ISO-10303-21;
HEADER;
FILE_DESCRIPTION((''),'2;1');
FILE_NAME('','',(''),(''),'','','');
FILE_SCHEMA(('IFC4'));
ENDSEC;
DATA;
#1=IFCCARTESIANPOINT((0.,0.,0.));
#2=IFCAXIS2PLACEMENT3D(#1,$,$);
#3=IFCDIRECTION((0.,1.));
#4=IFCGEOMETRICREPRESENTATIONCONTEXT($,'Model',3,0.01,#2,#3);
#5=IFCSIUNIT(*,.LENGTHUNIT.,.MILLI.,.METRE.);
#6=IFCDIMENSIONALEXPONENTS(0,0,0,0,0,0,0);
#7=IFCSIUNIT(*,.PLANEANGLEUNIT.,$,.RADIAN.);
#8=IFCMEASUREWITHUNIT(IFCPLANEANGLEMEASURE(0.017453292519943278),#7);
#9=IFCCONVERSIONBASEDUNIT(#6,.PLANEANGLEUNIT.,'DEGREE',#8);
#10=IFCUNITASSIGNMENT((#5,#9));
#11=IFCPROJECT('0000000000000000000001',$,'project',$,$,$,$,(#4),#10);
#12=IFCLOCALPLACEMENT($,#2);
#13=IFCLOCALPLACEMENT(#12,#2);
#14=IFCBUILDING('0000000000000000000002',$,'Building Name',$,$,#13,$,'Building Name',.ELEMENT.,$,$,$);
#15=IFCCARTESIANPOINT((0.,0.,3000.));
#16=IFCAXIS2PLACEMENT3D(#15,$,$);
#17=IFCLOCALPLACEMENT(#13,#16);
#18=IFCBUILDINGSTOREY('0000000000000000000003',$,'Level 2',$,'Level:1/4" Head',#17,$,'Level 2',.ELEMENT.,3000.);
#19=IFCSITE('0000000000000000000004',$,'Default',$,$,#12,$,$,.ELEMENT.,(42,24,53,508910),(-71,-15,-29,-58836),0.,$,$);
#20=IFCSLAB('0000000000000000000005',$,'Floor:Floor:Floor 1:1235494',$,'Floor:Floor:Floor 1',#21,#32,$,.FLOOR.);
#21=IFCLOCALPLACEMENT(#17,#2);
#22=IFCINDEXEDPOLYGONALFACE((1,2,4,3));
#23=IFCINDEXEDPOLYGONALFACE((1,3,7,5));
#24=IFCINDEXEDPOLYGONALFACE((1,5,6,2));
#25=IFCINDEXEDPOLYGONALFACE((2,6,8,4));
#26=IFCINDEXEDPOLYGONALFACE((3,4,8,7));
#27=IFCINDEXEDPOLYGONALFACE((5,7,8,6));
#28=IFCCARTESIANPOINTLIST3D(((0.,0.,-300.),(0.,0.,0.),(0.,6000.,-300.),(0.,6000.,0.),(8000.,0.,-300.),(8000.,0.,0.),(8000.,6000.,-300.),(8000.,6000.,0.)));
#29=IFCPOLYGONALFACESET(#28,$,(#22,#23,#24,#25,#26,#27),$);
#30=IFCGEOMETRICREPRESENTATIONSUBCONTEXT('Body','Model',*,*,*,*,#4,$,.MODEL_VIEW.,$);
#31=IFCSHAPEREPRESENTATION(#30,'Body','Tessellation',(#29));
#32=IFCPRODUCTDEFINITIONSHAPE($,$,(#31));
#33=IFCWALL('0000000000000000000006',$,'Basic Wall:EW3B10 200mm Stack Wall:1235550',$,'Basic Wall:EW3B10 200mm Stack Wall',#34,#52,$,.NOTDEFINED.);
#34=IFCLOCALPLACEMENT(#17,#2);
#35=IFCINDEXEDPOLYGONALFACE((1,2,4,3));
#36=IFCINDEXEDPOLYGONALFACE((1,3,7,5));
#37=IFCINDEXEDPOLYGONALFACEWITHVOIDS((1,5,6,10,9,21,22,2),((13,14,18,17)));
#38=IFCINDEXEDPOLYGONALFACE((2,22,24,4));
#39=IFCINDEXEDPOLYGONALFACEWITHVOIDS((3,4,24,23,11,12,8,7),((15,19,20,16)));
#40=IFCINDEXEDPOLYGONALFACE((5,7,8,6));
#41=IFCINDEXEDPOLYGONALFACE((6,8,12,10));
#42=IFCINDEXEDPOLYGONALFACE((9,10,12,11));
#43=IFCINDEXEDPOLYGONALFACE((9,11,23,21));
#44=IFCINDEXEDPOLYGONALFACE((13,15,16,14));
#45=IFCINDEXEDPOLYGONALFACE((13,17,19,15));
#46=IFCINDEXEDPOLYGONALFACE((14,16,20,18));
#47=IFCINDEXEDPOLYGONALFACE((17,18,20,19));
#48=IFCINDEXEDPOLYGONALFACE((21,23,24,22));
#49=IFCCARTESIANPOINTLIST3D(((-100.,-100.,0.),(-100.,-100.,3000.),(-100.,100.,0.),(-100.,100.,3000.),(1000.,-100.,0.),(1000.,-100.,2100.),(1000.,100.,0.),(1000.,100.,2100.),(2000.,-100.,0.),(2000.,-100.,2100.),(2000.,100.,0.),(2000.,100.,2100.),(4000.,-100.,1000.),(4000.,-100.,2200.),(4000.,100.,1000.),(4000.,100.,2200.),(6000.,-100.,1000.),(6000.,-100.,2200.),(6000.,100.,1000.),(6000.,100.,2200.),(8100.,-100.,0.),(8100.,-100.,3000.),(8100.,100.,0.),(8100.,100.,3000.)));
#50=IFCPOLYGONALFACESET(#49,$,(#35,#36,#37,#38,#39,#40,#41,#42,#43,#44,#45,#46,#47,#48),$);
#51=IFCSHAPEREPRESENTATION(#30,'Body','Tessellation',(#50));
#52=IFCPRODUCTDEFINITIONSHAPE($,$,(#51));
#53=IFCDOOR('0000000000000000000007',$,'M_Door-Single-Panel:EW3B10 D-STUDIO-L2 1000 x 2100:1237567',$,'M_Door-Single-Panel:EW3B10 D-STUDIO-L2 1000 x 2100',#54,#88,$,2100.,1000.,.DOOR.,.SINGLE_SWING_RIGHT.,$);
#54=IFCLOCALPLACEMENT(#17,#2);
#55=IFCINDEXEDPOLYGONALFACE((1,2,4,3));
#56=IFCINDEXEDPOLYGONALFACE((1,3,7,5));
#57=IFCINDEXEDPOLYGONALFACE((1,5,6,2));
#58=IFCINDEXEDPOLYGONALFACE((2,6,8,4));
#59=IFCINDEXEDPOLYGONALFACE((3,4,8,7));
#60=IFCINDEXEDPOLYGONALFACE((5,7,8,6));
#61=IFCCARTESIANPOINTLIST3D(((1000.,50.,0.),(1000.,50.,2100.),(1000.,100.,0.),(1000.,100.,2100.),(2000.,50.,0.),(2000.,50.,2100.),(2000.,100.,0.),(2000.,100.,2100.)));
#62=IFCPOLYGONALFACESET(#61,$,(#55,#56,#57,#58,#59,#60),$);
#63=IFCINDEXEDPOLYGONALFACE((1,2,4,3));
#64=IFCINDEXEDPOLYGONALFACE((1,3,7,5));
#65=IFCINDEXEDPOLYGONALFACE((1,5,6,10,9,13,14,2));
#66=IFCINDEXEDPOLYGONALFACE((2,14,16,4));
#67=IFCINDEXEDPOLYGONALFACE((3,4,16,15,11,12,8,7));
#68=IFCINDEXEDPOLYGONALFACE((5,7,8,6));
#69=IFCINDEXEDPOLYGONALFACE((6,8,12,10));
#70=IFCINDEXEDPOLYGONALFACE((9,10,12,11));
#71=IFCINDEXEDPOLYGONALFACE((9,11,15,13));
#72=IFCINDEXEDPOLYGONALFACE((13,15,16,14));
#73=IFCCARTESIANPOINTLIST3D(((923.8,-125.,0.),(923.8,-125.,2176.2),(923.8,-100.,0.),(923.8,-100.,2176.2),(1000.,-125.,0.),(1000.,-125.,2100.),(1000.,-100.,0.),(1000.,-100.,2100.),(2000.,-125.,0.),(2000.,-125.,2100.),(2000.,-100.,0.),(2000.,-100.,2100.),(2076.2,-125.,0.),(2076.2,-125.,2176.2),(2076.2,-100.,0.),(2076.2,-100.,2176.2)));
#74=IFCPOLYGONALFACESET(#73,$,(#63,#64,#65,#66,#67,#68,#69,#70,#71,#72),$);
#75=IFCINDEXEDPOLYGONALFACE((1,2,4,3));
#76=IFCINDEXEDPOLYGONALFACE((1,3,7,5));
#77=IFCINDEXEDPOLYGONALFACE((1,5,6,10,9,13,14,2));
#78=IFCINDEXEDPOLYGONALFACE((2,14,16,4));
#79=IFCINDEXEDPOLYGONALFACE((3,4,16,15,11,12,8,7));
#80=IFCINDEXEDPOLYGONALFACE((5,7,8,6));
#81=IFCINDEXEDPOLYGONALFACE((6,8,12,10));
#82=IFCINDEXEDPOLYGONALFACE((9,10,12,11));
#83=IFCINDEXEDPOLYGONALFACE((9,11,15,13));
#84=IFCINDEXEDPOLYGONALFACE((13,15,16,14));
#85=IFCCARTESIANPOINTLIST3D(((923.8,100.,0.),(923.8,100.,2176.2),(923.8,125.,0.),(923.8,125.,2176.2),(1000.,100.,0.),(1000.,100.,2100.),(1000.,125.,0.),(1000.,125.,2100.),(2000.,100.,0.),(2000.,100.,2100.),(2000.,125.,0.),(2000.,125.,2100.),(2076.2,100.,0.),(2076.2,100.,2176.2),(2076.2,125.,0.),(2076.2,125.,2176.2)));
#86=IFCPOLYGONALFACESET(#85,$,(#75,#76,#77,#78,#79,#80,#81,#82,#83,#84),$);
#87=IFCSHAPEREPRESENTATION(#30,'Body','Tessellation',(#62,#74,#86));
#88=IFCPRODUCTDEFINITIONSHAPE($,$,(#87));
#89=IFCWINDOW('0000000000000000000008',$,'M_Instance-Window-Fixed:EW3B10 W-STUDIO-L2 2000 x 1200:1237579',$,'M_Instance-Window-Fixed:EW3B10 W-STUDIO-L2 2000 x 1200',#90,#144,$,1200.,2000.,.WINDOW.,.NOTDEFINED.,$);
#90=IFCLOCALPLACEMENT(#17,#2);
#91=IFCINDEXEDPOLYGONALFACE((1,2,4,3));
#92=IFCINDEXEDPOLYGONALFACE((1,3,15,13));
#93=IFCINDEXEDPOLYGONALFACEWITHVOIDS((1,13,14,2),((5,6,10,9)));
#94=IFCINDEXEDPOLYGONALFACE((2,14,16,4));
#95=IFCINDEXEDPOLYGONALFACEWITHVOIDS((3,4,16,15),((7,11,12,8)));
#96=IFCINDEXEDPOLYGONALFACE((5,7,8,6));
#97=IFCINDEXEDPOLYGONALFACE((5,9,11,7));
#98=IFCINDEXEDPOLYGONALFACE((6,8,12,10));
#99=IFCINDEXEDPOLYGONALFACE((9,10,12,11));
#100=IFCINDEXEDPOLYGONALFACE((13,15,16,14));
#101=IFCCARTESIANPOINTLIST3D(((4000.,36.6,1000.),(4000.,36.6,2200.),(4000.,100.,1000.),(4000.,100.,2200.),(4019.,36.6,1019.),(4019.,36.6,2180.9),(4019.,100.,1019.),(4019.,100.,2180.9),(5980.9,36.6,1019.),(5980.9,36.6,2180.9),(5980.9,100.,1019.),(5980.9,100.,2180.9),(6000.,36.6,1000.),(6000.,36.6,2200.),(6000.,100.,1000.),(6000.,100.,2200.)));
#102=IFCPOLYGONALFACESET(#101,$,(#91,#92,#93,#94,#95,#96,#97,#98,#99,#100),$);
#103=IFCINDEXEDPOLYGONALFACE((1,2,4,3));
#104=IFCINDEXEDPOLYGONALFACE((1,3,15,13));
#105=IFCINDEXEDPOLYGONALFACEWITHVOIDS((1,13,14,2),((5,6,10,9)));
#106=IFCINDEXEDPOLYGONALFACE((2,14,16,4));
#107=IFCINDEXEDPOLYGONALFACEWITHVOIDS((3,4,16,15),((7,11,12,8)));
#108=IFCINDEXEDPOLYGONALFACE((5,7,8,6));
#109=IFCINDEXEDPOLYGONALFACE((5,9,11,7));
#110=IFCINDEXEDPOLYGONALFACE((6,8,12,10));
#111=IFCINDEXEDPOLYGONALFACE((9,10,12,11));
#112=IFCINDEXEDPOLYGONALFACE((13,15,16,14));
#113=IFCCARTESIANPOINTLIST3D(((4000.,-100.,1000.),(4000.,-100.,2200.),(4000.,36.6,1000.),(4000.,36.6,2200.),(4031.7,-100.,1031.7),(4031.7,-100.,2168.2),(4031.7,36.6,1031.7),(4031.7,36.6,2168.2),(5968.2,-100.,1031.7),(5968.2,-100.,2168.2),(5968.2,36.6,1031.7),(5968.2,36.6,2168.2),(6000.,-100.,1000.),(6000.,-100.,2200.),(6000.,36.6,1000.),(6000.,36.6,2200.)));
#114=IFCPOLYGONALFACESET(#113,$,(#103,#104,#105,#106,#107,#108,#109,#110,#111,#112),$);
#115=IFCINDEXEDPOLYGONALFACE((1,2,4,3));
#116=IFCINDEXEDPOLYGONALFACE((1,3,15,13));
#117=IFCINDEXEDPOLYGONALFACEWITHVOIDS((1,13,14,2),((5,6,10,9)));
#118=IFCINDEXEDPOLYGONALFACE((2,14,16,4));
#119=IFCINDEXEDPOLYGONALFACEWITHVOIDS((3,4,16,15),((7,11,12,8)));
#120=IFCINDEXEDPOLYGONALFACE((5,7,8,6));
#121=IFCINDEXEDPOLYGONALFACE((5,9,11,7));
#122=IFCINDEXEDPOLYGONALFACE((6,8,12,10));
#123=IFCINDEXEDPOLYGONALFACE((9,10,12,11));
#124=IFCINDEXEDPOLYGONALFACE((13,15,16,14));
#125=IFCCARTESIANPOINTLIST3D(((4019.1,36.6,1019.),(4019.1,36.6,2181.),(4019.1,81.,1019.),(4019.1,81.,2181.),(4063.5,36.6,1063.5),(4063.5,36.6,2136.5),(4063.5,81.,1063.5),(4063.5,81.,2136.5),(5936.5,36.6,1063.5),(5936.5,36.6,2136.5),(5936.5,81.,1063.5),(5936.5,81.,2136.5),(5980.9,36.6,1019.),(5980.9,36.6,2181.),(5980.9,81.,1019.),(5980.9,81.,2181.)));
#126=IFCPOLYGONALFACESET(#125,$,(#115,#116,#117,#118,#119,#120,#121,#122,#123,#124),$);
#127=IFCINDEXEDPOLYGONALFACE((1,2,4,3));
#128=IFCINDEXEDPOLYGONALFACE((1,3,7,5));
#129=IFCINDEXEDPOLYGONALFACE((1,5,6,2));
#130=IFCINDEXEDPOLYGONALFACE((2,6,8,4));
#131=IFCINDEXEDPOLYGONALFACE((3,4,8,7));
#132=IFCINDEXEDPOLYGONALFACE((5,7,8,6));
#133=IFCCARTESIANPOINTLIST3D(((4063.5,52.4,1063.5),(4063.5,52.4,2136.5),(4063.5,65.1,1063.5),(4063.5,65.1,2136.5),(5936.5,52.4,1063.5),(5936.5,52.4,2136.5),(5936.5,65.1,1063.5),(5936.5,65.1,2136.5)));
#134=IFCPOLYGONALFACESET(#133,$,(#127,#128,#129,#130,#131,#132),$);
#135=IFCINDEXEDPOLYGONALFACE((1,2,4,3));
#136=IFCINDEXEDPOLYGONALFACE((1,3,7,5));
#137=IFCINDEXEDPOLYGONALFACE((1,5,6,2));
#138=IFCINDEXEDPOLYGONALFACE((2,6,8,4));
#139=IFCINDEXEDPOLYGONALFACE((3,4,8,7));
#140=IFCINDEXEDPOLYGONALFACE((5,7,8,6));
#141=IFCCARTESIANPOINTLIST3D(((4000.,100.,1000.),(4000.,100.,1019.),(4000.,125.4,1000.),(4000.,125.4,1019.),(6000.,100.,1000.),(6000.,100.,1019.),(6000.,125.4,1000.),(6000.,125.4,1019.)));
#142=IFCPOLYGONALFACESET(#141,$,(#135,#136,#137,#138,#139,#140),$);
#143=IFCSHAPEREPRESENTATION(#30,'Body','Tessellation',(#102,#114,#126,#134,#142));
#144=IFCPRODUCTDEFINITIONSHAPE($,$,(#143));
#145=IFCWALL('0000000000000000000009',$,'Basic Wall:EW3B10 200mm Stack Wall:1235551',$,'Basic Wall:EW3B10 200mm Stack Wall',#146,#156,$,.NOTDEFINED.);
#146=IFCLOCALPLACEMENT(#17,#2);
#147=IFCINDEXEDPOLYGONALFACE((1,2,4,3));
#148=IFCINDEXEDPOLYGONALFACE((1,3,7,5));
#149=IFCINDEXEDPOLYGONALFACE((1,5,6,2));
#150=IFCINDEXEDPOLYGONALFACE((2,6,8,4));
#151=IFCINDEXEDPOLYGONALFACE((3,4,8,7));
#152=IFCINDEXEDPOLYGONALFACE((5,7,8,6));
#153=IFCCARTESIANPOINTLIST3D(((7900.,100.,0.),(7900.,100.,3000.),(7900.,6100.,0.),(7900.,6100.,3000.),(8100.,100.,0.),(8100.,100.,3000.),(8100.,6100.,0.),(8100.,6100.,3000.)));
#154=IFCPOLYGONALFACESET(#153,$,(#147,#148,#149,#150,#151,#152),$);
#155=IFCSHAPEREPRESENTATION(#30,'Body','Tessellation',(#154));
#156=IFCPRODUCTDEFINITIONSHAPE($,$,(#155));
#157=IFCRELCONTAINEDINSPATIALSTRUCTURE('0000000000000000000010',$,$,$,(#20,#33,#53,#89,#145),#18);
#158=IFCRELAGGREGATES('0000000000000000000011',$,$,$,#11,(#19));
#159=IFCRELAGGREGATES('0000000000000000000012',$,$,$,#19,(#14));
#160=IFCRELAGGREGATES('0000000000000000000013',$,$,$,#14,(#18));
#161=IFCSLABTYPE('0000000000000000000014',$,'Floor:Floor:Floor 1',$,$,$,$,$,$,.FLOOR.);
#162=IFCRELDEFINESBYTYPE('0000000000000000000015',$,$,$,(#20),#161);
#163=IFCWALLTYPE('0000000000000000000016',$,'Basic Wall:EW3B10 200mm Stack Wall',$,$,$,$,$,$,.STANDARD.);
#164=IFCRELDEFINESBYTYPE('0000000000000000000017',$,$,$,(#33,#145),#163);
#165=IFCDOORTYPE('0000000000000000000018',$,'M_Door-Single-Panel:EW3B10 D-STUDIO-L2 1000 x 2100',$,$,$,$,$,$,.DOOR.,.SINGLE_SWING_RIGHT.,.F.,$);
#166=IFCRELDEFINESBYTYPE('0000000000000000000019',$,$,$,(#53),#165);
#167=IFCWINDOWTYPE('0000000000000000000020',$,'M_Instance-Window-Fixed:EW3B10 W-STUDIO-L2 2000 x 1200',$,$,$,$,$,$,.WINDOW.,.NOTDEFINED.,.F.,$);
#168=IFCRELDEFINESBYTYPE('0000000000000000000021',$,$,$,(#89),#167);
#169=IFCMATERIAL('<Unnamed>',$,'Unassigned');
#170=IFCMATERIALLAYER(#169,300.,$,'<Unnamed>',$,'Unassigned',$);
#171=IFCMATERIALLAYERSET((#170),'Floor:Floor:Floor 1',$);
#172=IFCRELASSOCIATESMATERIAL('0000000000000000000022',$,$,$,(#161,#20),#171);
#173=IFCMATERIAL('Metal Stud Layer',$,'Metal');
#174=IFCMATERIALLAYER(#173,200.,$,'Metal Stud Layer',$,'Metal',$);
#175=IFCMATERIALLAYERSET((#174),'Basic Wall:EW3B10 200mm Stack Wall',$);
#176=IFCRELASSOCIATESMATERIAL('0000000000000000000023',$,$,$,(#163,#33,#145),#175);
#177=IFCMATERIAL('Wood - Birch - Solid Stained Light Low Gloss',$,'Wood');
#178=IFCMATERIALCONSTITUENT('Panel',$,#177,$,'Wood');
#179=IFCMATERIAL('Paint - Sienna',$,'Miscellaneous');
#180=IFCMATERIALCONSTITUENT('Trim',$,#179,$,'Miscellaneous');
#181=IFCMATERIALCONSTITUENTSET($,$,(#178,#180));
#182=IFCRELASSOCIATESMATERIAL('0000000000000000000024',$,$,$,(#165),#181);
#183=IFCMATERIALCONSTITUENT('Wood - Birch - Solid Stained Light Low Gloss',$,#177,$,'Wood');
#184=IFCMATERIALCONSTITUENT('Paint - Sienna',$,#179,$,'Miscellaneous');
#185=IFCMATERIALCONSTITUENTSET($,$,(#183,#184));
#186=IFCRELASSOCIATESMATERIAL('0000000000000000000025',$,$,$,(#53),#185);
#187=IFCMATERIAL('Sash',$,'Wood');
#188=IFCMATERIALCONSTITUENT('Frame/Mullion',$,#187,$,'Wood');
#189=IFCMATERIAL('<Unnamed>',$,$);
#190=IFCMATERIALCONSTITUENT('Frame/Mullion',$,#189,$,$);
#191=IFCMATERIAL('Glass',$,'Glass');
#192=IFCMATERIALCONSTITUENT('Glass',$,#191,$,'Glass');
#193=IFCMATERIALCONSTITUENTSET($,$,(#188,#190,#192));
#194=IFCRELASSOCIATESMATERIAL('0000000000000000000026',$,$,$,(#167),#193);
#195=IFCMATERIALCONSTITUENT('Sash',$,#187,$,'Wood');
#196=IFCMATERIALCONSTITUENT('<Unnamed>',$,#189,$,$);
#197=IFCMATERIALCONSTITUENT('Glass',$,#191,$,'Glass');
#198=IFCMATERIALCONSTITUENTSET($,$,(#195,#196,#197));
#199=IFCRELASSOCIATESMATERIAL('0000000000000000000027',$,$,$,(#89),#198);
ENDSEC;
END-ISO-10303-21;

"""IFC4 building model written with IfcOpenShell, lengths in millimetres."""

from ifc_helpers import new_model, entity, si_unit, converted_unit, direction, frame, frame_2d, origin, origin_2d_with_axis, place, context, subcontext, project, spatial, polyline, rectangle, outline, extrude, source, transform, mapped, material, layer, layer_set, layer_usage, constituent, constituent_set, type_object, type_shapes, element, fill, save


model = new_model("IFC4")

# Units and contexts
model_context = context("Model", 3, precision=0.01, world=origin(), true_north=direction((0.0, 1.0)))
body_context = subcontext(model_context, "Body", "Model", "MODEL_VIEW")
ifc_project = project(units=[si_unit("LENGTHUNIT", "METRE", prefix="MILLI"), converted_unit("PLANEANGLEUNIT", "DEGREE", entity("IfcPlaneAngleMeasure", 0.017453292519943278), si_unit("PLANEANGLEUNIT", "RADIAN"), dimensions=[0, 0, 0, 0, 0, 0, 0])], contexts=[model_context])

# Site, building, storey
site_placement = place(None, origin())
site = spatial("IfcSite", under=ifc_project, at=site_placement, Name="Default", CompositionType="ELEMENT", RefLatitude=(42, 24, 53, 508910), RefLongitude=(-71, -15, -29, -58836), RefElevation=0.0)
building_placement = place(site_placement, origin())
building = spatial("IfcBuilding", under=site, at=building_placement, Name="Building Name", LongName="Building Name", CompositionType="ELEMENT")
storey_placement = place(building_placement, frame((0.0, 0.0, 3000.0)))
storey = spatial("IfcBuildingStorey", under=building, at=storey_placement, Name="Level 2", ObjectType="Level:1/4\" Head", LongName="Level 2", CompositionType="ELEMENT", Elevation=3000.0)

# Slab
ifc_material_1 = material(Name="<Unnamed>", Category="Unassigned")
ifc_layer_1 = layer(ifc_material_1, 300.0, Name="<Unnamed>", Category="Unassigned")
ifc_layer_set_1 = layer_set([ifc_layer_1], Name="Floor:Floor:Floor 1")
ifc_layer_usage_1 = layer_usage(ifc_layer_set_1, "AXIS3", "POSITIVE", 0.0)
slab_type = type_object("IfcSlabType", Name="Floor:Floor:Floor 1", PredefinedType="FLOOR", material=ifc_layer_set_1)
slab_placement = place(storey_placement, origin())
element("IfcSlab", 1, at=slab_placement, inside=storey, type_object=slab_type, material=ifc_layer_usage_1, Name="Floor:Floor:Floor 1:1235494", ObjectType="Floor:Floor:Floor 1", PredefinedType="FLOOR", context=body_context, shape_type="SweptSolid", body=[
    extrude(rectangle(XDim=6000.0, YDim=8000.0, at=origin_2d_with_axis()), frame((4000.0, 3000.0, 0.0), z_axis=(0.0, 0.0, -1.0), x_axis=(0.0, 1.0, 0.0)), (0.0, 0.0, 1.0), 300.0),
])

# Wall, openings, door, window
ifc_material_2 = material(Name="Metal Stud Layer", Category="Metal")
ifc_layer_2 = layer(ifc_material_2, 200.0, Name="Metal Stud Layer", Category="Metal")
ifc_layer_set_2 = layer_set([ifc_layer_2], Name="Basic Wall:EW3B10 200mm Stack Wall")
ifc_layer_usage_2 = layer_usage(ifc_layer_set_2, "AXIS2", "NEGATIVE", 100.0)
wall_type = type_object("IfcWallType", Name="Basic Wall:EW3B10 200mm Stack Wall", PredefinedType="STANDARD", material=ifc_layer_set_2)
wall_1_placement = place(storey_placement, frame((-100.0, 0.0, 0.0)))
wall_1 = element("IfcWall", 2, at=wall_1_placement, inside=storey, type_object=wall_type, material=ifc_layer_usage_2, Name="Basic Wall:EW3B10 200mm Stack Wall:1235550", ObjectType="Basic Wall:EW3B10 200mm Stack Wall", PredefinedType="NOTDEFINED", context=body_context, shape_type="SweptSolid", body=[
    extrude(rectangle(XDim=8200.0, YDim=200.0, at=frame_2d((4100.0, 0.0), x_axis=(1.0, 0.0))), origin(), (0.0, 0.0, 1.0), 3000.0),
])
opening_1_placement = place(wall_1_placement, frame((1100.0, -100.0, 0.0)))
opening_1 = element("IfcOpeningElement", 3, at=opening_1_placement, cuts=wall_1, PredefinedType="OPENING", context=body_context, shape_type="SweptSolid", body=[
    extrude(rectangle(XDim=1000.0, YDim=2100.0, at=frame_2d((1050.0, 500.0), x_axis=(0.0, 1.0))), frame((0.0, 0.0, 0.0), z_axis=(0.0, 1.0, 0.0), x_axis=(0.0, 0.0, 1.0)), (0.0, 0.0, 1.0), 200.0),
])
opening_2_placement = place(wall_1_placement, frame((4100.0, -100.0, 1000.0)))
opening_2 = element("IfcOpeningElement", 4, at=opening_2_placement, cuts=wall_1, PredefinedType="OPENING", context=body_context, shape_type="SweptSolid", body=[
    extrude(rectangle(XDim=1200.0, YDim=2000.0, at=frame_2d((600.0, 1000.0), x_axis=(-1.0, 0.0))), frame((0.0, 0.0, 0.0), z_axis=(0.0, 1.0, 0.0), x_axis=(0.0, 0.0, 1.0)), (0.0, 0.0, 1.0), 200.0),
])
ifc_material_3 = material(Name="Wood - Birch - Solid Stained Light Low Gloss", Category="Wood")
ifc_constituent_1 = constituent(ifc_material_3, Name="Wood - Birch - Solid Stained Light Low Gloss", Category="Wood")
ifc_material_4 = material(Name="Paint - Sienna", Category="Miscellaneous")
ifc_constituent_2 = constituent(ifc_material_4, Name="Paint - Sienna", Category="Miscellaneous")
ifc_constituent_set_1 = constituent_set(constituents=[ifc_constituent_1, ifc_constituent_2])
ifc_constituent_3 = constituent(ifc_material_3, Name="Panel", Category="Wood")
ifc_constituent_4 = constituent(ifc_material_4, Name="Trim", Category="Miscellaneous")
ifc_constituent_set_2 = constituent_set(constituents=[ifc_constituent_3, ifc_constituent_4])
door_type = type_object("IfcDoorType", Name="M_Door-Single-Panel:EW3B10 D-STUDIO-L2 1000 x 2100", OperationType="SINGLE_SWING_RIGHT", ParameterTakesPrecedence=False, PredefinedType="DOOR", material=ifc_constituent_set_2)
shared_shape_1 = source(origin(), body_context, "Body", "SweptSolid", [
    extrude(rectangle(XDim=50.0, YDim=1000.0, at=frame_2d((0.0, 0.0), x_axis=(1.0, 0.0))), frame((500.0, 175.0, 0.0), z_axis=(0.0, 0.0, 1.0), x_axis=(0.0, 1.0, 0.0)), (0.0, 0.0, 1.0), 2100.0),
    extrude(outline(polyline([(-1107.1, -576.2), (1069.0, -576.2), (1069.0, -500.0), (-1030.9, -500.0), (-1030.9, 500.0), (1069.0, 500.0), (1069.0, 576.2), (-1107.1, 576.2), (-1107.1, -576.2)])), frame((500.0, -25.0, 1069.0), z_axis=(0.0, 1.0, 0.0), x_axis=(0.0, 0.0, -1.0)), (0.0, 0.0, 1.0), 25.0),
    extrude(outline(polyline([(-576.2, -1107.1), (576.2, -1107.1), (576.2, 1069.1), (500.0, 1069.1), (500.0, -1031.0), (-500.0, -1031.0), (-500.0, 1069.1), (-576.2, 1069.1), (-576.2, -1107.1)])), frame((500.0, 200.0, 1069.1), z_axis=(0.0, 1.0, 0.0), x_axis=(1.0, 0.0, 0.0)), (0.0, 0.0, 1.0), 25.0),
])
type_shapes(door_type, [shared_shape_1])
door_placement = place(opening_1_placement, origin())
door = element("IfcDoor", 5, at=door_placement, inside=storey, type_object=door_type, material=ifc_constituent_set_1, Name="M_Door-Single-Panel:EW3B10 D-STUDIO-L2 1000 x 2100:1237567", ObjectType="M_Door-Single-Panel:EW3B10 D-STUDIO-L2 1000 x 2100", OperationType="SINGLE_SWING_RIGHT", OverallHeight=2100.0, OverallWidth=1000.0, PredefinedType="DOOR", context=body_context, shape_type="MappedRepresentation", body=[
    mapped(shared_shape_1, transform((0.0, 0.0, 0.0), scale=1.0)),
])
fill(opening_1, door)
ifc_material_5 = material(Name="Sash", Category="Wood")
ifc_constituent_5 = constituent(ifc_material_5, Name="Sash", Category="Wood")
ifc_material_6 = material(Name="<Unnamed>")
ifc_constituent_6 = constituent(ifc_material_6, Name="<Unnamed>")
ifc_material_7 = material(Name="Glass", Category="Glass")
ifc_constituent_7 = constituent(ifc_material_7, Name="Glass", Category="Glass")
ifc_constituent_set_3 = constituent_set(constituents=[ifc_constituent_5, ifc_constituent_6, ifc_constituent_7])
ifc_constituent_8 = constituent(ifc_material_5, Name="Frame/Mullion", Category="Wood")
ifc_constituent_9 = constituent(ifc_material_6, Name="Frame/Mullion")
ifc_constituent_10 = constituent(ifc_material_7, Name="Glass", Category="Glass")
ifc_constituent_set_4 = constituent_set(constituents=[ifc_constituent_8, ifc_constituent_9, ifc_constituent_10])
window_type = type_object("IfcWindowType", Name="M_Instance-Window-Fixed:EW3B10 W-STUDIO-L2 2000 x 1200", ParameterTakesPrecedence=False, PartitioningType="NOTDEFINED", PredefinedType="WINDOW", material=ifc_constituent_set_4)
shared_shape_2 = source(origin(), body_context, "Body", "SweptSolid", [
    extrude(outline(polyline([(-600.0, -1000.0), (600.0, -1000.0), (600.0, 1000.0), (-600.0, 1000.0), (-600.0, -1000.0)]), holes=[polyline([(-580.9, -980.9), (-580.9, 981.0), (581.0, 981.0), (581.0, -980.9), (-580.9, -980.9)])]), frame((1000.0, 136.6, 600.0), z_axis=(0.0, 1.0, 0.0), x_axis=(0.0, 0.0, -1.0)), (0.0, 0.0, 1.0), 63.5),
    extrude(outline(polyline([(-1000.0, -600.0), (1000.0, -600.0), (1000.0, 600.0), (-1000.0, 600.0), (-1000.0, -600.0)]), holes=[polyline([(-968.3, -568.2), (-968.3, 568.3), (968.2, 568.3), (968.2, -568.2), (-968.3, -568.2)])]), frame((1000.0, 0.0, 600.0), z_axis=(0.0, 1.0, 0.0), x_axis=(1.0, 0.0, 0.0)), (0.0, 0.0, 1.0), 136.6),
    extrude(outline(polyline([(-980.9, -581.0), (980.9, -581.0), (980.9, 581.0), (-980.9, 581.0), (-980.9, -581.0)]), holes=[polyline([(-936.5, -536.5), (-936.5, 536.5), (936.5, 536.5), (936.5, -536.5), (-936.5, -536.5)])]), frame((1000.0, 136.6, 600.0), z_axis=(0.0, 1.0, 0.0), x_axis=(1.0, 0.0, 0.0)), (0.0, 0.0, 1.0), 44.4),
    extrude(rectangle(XDim=12.7, YDim=1873.0, at=frame_2d((0.0, 0.0), x_axis=(1.0, 0.0))), frame((1000.0, 158.8, 63.5), z_axis=(0.0, 0.0, 1.0), x_axis=(0.0, 1.0, 0.0)), (0.0, 0.0, 1.0), 1073.0),
    extrude(rectangle(XDim=25.4, YDim=2000.0, at=frame_2d((0.0, 0.0), x_axis=(1.0, 0.0))), frame((1000.0, 212.7, 0.0), z_axis=(0.0, 0.0, 1.0), x_axis=(0.0, -1.0, 0.0)), (0.0, 0.0, 1.0), 19.0),
])
type_shapes(window_type, [shared_shape_2])
window_placement = place(opening_2_placement, origin())
window = element("IfcWindow", 6, at=window_placement, inside=storey, type_object=window_type, material=ifc_constituent_set_3, Name="M_Instance-Window-Fixed:EW3B10 W-STUDIO-L2 2000 x 1200:1237579", ObjectType="M_Instance-Window-Fixed:EW3B10 W-STUDIO-L2 2000 x 1200", OverallHeight=1200.0, OverallWidth=2000.0, PartitioningType="NOTDEFINED", PredefinedType="WINDOW", context=body_context, shape_type="MappedRepresentation", body=[
    mapped(shared_shape_2, transform((0.0, 0.0, 0.0), scale=1.0)),
])
fill(opening_2, window)

# Wall
ifc_layer_usage_3 = layer_usage(ifc_layer_set_2, "AXIS2", "NEGATIVE", 100.0)
wall_2_placement = place(storey_placement, frame((8000.0, 100.0, 0.0), z_axis=(0.0, 0.0, 1.0), x_axis=(0.0, 1.0, 0.0)))
element("IfcWall", 7, at=wall_2_placement, inside=storey, type_object=wall_type, material=ifc_layer_usage_3, Name="Basic Wall:EW3B10 200mm Stack Wall:1235551", ObjectType="Basic Wall:EW3B10 200mm Stack Wall", PredefinedType="NOTDEFINED", context=body_context, shape_type="SweptSolid", body=[
    extrude(rectangle(XDim=6000.0, YDim=200.0, at=frame_2d((3000.0, 0.0), x_axis=(-1.0, 0.0))), origin(), (0.0, 0.0, 1.0), 3000.0),
])

save(model, "model.ifc")
